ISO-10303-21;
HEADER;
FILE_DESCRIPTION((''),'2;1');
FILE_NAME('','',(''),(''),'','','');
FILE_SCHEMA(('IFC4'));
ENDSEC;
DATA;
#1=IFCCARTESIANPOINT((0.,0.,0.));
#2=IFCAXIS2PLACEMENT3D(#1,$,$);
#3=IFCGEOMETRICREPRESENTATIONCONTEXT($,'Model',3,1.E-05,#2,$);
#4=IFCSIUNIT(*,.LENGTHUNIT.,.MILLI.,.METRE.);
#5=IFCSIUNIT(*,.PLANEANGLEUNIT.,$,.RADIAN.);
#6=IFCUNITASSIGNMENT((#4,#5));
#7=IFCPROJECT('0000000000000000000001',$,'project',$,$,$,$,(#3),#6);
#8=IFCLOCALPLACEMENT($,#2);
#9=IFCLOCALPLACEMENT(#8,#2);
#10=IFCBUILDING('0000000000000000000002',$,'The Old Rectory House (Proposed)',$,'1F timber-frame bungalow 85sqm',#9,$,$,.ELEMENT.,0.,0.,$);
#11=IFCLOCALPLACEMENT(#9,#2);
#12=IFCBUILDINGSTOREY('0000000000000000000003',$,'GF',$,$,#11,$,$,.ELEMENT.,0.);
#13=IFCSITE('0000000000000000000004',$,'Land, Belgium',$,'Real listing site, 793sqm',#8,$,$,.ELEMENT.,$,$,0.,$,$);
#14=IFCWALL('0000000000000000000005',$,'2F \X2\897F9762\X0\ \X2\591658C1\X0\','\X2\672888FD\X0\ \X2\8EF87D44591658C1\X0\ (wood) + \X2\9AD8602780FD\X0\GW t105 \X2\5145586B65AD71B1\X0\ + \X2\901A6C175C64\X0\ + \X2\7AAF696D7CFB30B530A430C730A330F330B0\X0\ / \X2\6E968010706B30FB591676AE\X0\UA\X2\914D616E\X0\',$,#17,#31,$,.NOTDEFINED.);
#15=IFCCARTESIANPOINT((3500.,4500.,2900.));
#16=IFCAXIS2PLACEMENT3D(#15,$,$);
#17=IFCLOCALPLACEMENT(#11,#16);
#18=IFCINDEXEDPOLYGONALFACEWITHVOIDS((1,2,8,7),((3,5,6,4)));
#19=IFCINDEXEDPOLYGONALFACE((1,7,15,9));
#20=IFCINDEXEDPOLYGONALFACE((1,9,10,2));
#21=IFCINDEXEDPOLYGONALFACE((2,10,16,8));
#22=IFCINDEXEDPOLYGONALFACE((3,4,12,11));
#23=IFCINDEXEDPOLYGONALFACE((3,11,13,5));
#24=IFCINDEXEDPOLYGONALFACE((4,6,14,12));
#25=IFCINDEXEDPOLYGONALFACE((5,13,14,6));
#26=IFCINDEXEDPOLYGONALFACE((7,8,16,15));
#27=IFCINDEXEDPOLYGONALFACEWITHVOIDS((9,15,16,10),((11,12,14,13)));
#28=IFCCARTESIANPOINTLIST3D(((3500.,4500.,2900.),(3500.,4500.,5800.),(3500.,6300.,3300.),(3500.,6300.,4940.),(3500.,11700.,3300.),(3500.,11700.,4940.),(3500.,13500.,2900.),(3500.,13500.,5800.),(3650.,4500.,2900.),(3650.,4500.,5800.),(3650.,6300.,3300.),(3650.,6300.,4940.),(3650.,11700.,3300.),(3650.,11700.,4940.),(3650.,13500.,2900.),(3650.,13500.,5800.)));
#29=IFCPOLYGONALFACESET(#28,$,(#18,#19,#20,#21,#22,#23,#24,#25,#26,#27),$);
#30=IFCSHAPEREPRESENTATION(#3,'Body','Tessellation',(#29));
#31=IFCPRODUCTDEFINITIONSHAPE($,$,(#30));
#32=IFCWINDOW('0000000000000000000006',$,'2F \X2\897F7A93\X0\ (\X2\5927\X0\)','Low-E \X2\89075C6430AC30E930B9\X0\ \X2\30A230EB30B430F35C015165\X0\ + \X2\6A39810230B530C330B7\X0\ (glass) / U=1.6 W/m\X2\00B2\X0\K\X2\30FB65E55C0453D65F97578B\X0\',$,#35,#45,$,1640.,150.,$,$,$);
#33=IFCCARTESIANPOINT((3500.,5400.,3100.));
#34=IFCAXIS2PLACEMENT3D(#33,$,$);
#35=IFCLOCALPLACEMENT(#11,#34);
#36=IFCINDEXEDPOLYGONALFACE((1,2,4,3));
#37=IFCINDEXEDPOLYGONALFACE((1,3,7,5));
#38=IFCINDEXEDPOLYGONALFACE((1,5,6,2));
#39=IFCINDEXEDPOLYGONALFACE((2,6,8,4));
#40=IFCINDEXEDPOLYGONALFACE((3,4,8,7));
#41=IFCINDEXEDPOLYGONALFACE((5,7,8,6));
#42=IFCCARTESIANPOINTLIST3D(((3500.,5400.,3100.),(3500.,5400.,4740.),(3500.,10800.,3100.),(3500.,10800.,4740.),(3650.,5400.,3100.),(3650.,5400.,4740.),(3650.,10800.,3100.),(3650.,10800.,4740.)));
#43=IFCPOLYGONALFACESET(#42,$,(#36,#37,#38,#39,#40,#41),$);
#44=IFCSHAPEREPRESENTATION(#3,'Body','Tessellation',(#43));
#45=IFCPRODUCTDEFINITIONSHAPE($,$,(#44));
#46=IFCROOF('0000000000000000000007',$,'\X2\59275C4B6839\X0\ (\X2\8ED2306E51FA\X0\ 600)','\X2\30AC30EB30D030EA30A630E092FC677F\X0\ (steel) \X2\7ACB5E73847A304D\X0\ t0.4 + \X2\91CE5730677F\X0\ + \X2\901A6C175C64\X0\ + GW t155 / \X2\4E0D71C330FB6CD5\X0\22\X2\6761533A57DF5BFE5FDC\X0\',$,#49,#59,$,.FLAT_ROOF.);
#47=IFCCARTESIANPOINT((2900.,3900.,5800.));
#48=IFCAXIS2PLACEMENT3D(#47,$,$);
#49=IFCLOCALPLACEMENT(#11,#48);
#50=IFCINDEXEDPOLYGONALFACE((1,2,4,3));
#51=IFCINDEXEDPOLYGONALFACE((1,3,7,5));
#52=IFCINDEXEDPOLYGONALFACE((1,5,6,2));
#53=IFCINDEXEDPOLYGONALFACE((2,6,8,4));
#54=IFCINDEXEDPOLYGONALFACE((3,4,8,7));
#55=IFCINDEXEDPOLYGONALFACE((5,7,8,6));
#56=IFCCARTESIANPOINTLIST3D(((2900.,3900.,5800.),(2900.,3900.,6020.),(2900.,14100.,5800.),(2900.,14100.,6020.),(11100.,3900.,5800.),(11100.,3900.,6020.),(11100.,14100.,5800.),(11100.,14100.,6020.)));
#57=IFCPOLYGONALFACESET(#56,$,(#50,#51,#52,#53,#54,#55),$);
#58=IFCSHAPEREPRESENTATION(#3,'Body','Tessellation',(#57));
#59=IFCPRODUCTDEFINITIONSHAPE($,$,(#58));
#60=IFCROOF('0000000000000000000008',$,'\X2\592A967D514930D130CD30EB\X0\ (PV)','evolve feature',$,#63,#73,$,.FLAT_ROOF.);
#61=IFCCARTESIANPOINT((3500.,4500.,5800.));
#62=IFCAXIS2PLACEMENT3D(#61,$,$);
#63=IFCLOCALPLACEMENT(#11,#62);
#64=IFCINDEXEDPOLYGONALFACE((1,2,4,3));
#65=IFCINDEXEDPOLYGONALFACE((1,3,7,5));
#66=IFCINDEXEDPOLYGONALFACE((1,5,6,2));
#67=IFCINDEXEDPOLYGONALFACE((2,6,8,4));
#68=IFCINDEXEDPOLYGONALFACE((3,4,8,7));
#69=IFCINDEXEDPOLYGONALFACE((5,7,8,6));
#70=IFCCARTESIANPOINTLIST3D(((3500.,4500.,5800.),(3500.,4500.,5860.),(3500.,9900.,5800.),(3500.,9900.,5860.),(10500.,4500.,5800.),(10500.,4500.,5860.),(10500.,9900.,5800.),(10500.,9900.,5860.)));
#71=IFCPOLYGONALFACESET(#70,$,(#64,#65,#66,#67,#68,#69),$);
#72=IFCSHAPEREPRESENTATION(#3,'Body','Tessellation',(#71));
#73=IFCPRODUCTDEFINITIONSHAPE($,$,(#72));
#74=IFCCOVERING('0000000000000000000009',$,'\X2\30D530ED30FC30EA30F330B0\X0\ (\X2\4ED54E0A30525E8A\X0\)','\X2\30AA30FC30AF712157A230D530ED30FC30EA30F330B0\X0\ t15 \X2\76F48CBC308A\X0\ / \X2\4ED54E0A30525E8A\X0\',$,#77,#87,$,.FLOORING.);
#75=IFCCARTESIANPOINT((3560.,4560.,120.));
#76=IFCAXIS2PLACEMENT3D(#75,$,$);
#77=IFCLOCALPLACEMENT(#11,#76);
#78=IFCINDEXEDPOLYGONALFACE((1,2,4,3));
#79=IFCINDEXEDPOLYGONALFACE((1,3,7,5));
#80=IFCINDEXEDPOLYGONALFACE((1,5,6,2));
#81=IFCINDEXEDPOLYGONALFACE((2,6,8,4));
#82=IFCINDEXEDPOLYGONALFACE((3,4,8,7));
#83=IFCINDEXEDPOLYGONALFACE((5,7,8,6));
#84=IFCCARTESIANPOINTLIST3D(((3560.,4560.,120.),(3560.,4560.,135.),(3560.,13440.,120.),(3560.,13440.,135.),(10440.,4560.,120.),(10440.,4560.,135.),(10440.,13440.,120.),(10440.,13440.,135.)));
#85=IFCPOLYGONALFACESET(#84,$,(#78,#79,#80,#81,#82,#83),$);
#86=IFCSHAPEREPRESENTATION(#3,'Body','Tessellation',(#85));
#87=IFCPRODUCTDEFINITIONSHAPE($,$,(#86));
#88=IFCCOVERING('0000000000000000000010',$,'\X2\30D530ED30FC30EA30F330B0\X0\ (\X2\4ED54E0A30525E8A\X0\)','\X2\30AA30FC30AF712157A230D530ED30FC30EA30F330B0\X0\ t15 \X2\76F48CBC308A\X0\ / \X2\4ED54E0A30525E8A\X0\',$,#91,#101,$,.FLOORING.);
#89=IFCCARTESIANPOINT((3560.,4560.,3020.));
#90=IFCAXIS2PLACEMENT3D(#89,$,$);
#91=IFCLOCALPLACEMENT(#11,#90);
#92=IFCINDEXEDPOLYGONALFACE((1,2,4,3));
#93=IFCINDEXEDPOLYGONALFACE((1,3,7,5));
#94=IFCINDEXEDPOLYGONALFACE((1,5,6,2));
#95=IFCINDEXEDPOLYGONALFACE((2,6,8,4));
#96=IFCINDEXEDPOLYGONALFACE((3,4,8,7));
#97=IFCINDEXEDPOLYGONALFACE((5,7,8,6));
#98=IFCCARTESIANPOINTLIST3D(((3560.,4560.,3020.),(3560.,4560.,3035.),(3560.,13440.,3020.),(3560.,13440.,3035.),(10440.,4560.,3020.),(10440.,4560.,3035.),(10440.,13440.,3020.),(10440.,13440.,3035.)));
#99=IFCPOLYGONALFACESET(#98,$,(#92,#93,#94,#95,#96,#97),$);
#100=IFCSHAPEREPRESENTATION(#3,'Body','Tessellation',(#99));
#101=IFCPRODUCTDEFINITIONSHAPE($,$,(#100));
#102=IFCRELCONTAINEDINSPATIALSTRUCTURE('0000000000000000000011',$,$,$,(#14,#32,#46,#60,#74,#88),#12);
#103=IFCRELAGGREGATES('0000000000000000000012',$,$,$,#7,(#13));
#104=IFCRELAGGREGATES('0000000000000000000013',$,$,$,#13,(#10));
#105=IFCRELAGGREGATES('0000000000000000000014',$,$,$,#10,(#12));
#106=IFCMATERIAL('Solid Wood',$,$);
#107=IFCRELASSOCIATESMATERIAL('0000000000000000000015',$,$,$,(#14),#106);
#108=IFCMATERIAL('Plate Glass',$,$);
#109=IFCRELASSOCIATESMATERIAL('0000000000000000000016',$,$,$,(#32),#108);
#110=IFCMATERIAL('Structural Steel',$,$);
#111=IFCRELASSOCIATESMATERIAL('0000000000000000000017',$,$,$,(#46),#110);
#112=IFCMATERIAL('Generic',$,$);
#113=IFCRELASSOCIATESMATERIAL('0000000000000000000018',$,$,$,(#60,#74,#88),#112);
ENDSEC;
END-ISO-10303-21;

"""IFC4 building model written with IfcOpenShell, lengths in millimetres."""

from ifc_helpers import new_model, si_unit, frame, frame_2d, origin, place, context, project, spatial, rectangle, extrude, material, element, fill, save


model = new_model("IFC4")

# Units and contexts
model_context = context("Model", 3, precision=1e-05, world=origin())
ifc_project = project(units=[si_unit("LENGTHUNIT", "METRE", prefix="MILLI"), si_unit("PLANEANGLEUNIT", "RADIAN")], contexts=[model_context])

# Site, building, storey
site_placement = place(None, origin())
site = spatial("IfcSite", under=ifc_project, at=site_placement, Name="Land, Belgium", ObjectType="Real listing site, 793sqm", CompositionType="ELEMENT", RefElevation=0.0)
building_placement = place(site_placement, origin())
building = spatial("IfcBuilding", under=site, at=building_placement, Name="The Old Rectory House (Proposed)", ObjectType="1F timber-frame bungalow 85sqm", CompositionType="ELEMENT", ElevationOfRefHeight=0.0, ElevationOfTerrain=0.0)
storey_placement = place(building_placement, origin())
storey = spatial("IfcBuildingStorey", under=building, at=storey_placement, Name="GF", CompositionType="ELEMENT", Elevation=0.0)

# Shared definitions
ifc_material_1 = material(Name="Solid Wood")
ifc_material_2 = material(Name="Generic")

# Shared definitions
ifc_material_3 = material(Name="Plate Glass")

# Wall, opening, window
wall_1_placement = place(storey_placement, frame((3500.0, 4500.0, 2900.0)))
wall_1 = element("IfcWall", 1, at=wall_1_placement, inside=storey, material=ifc_material_1, Name="2F 西面 外壁", Description="木製 軸組外壁 (wood) + 高性能GW t105 充填断熱 + 通気層 + 窯業系サイディング / 準耐火・外皮UA配慮", PredefinedType="NOTDEFINED", context=model_context, shape_type="SweptSolid", body=[
    extrude(rectangle(XDim=150.0, YDim=9000.0, at=frame_2d((75.0, 4500.0))), frame((3500.0, 4500.0, 2900.0)), (0.0, 0.0, 1.0), 2900.0),
])
opening_1_placement = place(storey_placement, frame((3500.0, 5400.0, 3100.0)))
opening_1 = element("IfcOpeningElement", 2, at=opening_1_placement, cuts=wall_1, PredefinedType="NOTDEFINED", context=model_context, shape_type="SweptSolid", body=[
    extrude(rectangle(XDim=150.0, YDim=5400.0, at=frame_2d((75.0, 2700.0))), frame((3500.0, 5400.0, 3100.0)), (0.0, 0.0, 1.0), 1640.0),
])
window_1_placement = place(storey_placement, frame((3500.0, 5400.0, 3100.0)))
window_1 = element("IfcWindow", 3, at=window_1_placement, inside=storey, material=ifc_material_3, Name="2F 西窓 (大)", Description="Low-E 複層ガラス アルゴン封入 + 樹脂サッシ (glass) / U=1.6 W/m²K・日射取得型", OverallHeight=1640.0, OverallWidth=150.0, context=model_context, shape_type="SweptSolid", body=[
    extrude(rectangle(XDim=150.0, YDim=5400.0, at=frame_2d((75.0, 2700.0))), frame((3500.0, 5400.0, 3100.0)), (0.0, 0.0, 1.0), 1640.0),
])
fill(opening_1, window_1)

# Roofs
ifc_material_4 = material(Name="Structural Steel")
roof_1_placement = place(storey_placement, frame((2900.0, 3900.0, 5800.0)))
element("IfcRoof", 4, at=roof_1_placement, inside=storey, material=ifc_material_4, Name="大屋根 (軒の出 600)", Description="ガルバリウム鋼板 (steel) 立平葺き t0.4 + 野地板 + 通気層 + GW t155 / 不燃・法22条区域対応", PredefinedType="FLAT_ROOF", context=model_context, shape_type="SweptSolid", body=[
    extrude(rectangle(XDim=8200.0, YDim=10200.0, at=frame_2d((4100.0, 5100.0))), frame((2900.0, 3900.0, 5800.0)), (0.0, 0.0, 1.0), 220.0),
])
roof_2_placement = place(storey_placement, frame((3500.0, 4500.0, 5800.0)))
element("IfcRoof", 5, at=roof_2_placement, inside=storey, material=ifc_material_2, Name="太陽光パネル (PV)", Description="evolve feature", PredefinedType="FLAT_ROOF", context=model_context, shape_type="SweptSolid", body=[
    extrude(rectangle(XDim=7000.0, YDim=5400.0, at=frame_2d((3500.0, 2700.0))), frame((3500.0, 4500.0, 5800.0)), (0.0, 0.0, 1.0), 60.0),
])

# Coverings
covering_1_placement = place(storey_placement, frame((3560.0, 4560.0, 120.0)))
element("IfcCovering", 6, at=covering_1_placement, inside=storey, material=ifc_material_2, Name="フローリング (仕上げ床)", Description="オーク無垢フローリング t15 直貼り / 仕上げ床", PredefinedType="FLOORING", context=model_context, shape_type="SweptSolid", body=[
    extrude(rectangle(XDim=6880.0, YDim=8880.0, at=frame_2d((3440.0, 4440.0))), frame((3560.0, 4560.0, 120.0)), (0.0, 0.0, 1.0), 15.0),
])
covering_2_placement = place(storey_placement, frame((3560.0, 4560.0, 3020.0)))
element("IfcCovering", 7, at=covering_2_placement, inside=storey, material=ifc_material_2, Name="フローリング (仕上げ床)", Description="オーク無垢フローリング t15 直貼り / 仕上げ床", PredefinedType="FLOORING", context=model_context, shape_type="SweptSolid", body=[
    extrude(rectangle(XDim=6880.0, YDim=8880.0, at=frame_2d((3440.0, 4440.0))), frame((3560.0, 4560.0, 3020.0)), (0.0, 0.0, 1.0), 15.0),
])

save(model, "model.ifc")
